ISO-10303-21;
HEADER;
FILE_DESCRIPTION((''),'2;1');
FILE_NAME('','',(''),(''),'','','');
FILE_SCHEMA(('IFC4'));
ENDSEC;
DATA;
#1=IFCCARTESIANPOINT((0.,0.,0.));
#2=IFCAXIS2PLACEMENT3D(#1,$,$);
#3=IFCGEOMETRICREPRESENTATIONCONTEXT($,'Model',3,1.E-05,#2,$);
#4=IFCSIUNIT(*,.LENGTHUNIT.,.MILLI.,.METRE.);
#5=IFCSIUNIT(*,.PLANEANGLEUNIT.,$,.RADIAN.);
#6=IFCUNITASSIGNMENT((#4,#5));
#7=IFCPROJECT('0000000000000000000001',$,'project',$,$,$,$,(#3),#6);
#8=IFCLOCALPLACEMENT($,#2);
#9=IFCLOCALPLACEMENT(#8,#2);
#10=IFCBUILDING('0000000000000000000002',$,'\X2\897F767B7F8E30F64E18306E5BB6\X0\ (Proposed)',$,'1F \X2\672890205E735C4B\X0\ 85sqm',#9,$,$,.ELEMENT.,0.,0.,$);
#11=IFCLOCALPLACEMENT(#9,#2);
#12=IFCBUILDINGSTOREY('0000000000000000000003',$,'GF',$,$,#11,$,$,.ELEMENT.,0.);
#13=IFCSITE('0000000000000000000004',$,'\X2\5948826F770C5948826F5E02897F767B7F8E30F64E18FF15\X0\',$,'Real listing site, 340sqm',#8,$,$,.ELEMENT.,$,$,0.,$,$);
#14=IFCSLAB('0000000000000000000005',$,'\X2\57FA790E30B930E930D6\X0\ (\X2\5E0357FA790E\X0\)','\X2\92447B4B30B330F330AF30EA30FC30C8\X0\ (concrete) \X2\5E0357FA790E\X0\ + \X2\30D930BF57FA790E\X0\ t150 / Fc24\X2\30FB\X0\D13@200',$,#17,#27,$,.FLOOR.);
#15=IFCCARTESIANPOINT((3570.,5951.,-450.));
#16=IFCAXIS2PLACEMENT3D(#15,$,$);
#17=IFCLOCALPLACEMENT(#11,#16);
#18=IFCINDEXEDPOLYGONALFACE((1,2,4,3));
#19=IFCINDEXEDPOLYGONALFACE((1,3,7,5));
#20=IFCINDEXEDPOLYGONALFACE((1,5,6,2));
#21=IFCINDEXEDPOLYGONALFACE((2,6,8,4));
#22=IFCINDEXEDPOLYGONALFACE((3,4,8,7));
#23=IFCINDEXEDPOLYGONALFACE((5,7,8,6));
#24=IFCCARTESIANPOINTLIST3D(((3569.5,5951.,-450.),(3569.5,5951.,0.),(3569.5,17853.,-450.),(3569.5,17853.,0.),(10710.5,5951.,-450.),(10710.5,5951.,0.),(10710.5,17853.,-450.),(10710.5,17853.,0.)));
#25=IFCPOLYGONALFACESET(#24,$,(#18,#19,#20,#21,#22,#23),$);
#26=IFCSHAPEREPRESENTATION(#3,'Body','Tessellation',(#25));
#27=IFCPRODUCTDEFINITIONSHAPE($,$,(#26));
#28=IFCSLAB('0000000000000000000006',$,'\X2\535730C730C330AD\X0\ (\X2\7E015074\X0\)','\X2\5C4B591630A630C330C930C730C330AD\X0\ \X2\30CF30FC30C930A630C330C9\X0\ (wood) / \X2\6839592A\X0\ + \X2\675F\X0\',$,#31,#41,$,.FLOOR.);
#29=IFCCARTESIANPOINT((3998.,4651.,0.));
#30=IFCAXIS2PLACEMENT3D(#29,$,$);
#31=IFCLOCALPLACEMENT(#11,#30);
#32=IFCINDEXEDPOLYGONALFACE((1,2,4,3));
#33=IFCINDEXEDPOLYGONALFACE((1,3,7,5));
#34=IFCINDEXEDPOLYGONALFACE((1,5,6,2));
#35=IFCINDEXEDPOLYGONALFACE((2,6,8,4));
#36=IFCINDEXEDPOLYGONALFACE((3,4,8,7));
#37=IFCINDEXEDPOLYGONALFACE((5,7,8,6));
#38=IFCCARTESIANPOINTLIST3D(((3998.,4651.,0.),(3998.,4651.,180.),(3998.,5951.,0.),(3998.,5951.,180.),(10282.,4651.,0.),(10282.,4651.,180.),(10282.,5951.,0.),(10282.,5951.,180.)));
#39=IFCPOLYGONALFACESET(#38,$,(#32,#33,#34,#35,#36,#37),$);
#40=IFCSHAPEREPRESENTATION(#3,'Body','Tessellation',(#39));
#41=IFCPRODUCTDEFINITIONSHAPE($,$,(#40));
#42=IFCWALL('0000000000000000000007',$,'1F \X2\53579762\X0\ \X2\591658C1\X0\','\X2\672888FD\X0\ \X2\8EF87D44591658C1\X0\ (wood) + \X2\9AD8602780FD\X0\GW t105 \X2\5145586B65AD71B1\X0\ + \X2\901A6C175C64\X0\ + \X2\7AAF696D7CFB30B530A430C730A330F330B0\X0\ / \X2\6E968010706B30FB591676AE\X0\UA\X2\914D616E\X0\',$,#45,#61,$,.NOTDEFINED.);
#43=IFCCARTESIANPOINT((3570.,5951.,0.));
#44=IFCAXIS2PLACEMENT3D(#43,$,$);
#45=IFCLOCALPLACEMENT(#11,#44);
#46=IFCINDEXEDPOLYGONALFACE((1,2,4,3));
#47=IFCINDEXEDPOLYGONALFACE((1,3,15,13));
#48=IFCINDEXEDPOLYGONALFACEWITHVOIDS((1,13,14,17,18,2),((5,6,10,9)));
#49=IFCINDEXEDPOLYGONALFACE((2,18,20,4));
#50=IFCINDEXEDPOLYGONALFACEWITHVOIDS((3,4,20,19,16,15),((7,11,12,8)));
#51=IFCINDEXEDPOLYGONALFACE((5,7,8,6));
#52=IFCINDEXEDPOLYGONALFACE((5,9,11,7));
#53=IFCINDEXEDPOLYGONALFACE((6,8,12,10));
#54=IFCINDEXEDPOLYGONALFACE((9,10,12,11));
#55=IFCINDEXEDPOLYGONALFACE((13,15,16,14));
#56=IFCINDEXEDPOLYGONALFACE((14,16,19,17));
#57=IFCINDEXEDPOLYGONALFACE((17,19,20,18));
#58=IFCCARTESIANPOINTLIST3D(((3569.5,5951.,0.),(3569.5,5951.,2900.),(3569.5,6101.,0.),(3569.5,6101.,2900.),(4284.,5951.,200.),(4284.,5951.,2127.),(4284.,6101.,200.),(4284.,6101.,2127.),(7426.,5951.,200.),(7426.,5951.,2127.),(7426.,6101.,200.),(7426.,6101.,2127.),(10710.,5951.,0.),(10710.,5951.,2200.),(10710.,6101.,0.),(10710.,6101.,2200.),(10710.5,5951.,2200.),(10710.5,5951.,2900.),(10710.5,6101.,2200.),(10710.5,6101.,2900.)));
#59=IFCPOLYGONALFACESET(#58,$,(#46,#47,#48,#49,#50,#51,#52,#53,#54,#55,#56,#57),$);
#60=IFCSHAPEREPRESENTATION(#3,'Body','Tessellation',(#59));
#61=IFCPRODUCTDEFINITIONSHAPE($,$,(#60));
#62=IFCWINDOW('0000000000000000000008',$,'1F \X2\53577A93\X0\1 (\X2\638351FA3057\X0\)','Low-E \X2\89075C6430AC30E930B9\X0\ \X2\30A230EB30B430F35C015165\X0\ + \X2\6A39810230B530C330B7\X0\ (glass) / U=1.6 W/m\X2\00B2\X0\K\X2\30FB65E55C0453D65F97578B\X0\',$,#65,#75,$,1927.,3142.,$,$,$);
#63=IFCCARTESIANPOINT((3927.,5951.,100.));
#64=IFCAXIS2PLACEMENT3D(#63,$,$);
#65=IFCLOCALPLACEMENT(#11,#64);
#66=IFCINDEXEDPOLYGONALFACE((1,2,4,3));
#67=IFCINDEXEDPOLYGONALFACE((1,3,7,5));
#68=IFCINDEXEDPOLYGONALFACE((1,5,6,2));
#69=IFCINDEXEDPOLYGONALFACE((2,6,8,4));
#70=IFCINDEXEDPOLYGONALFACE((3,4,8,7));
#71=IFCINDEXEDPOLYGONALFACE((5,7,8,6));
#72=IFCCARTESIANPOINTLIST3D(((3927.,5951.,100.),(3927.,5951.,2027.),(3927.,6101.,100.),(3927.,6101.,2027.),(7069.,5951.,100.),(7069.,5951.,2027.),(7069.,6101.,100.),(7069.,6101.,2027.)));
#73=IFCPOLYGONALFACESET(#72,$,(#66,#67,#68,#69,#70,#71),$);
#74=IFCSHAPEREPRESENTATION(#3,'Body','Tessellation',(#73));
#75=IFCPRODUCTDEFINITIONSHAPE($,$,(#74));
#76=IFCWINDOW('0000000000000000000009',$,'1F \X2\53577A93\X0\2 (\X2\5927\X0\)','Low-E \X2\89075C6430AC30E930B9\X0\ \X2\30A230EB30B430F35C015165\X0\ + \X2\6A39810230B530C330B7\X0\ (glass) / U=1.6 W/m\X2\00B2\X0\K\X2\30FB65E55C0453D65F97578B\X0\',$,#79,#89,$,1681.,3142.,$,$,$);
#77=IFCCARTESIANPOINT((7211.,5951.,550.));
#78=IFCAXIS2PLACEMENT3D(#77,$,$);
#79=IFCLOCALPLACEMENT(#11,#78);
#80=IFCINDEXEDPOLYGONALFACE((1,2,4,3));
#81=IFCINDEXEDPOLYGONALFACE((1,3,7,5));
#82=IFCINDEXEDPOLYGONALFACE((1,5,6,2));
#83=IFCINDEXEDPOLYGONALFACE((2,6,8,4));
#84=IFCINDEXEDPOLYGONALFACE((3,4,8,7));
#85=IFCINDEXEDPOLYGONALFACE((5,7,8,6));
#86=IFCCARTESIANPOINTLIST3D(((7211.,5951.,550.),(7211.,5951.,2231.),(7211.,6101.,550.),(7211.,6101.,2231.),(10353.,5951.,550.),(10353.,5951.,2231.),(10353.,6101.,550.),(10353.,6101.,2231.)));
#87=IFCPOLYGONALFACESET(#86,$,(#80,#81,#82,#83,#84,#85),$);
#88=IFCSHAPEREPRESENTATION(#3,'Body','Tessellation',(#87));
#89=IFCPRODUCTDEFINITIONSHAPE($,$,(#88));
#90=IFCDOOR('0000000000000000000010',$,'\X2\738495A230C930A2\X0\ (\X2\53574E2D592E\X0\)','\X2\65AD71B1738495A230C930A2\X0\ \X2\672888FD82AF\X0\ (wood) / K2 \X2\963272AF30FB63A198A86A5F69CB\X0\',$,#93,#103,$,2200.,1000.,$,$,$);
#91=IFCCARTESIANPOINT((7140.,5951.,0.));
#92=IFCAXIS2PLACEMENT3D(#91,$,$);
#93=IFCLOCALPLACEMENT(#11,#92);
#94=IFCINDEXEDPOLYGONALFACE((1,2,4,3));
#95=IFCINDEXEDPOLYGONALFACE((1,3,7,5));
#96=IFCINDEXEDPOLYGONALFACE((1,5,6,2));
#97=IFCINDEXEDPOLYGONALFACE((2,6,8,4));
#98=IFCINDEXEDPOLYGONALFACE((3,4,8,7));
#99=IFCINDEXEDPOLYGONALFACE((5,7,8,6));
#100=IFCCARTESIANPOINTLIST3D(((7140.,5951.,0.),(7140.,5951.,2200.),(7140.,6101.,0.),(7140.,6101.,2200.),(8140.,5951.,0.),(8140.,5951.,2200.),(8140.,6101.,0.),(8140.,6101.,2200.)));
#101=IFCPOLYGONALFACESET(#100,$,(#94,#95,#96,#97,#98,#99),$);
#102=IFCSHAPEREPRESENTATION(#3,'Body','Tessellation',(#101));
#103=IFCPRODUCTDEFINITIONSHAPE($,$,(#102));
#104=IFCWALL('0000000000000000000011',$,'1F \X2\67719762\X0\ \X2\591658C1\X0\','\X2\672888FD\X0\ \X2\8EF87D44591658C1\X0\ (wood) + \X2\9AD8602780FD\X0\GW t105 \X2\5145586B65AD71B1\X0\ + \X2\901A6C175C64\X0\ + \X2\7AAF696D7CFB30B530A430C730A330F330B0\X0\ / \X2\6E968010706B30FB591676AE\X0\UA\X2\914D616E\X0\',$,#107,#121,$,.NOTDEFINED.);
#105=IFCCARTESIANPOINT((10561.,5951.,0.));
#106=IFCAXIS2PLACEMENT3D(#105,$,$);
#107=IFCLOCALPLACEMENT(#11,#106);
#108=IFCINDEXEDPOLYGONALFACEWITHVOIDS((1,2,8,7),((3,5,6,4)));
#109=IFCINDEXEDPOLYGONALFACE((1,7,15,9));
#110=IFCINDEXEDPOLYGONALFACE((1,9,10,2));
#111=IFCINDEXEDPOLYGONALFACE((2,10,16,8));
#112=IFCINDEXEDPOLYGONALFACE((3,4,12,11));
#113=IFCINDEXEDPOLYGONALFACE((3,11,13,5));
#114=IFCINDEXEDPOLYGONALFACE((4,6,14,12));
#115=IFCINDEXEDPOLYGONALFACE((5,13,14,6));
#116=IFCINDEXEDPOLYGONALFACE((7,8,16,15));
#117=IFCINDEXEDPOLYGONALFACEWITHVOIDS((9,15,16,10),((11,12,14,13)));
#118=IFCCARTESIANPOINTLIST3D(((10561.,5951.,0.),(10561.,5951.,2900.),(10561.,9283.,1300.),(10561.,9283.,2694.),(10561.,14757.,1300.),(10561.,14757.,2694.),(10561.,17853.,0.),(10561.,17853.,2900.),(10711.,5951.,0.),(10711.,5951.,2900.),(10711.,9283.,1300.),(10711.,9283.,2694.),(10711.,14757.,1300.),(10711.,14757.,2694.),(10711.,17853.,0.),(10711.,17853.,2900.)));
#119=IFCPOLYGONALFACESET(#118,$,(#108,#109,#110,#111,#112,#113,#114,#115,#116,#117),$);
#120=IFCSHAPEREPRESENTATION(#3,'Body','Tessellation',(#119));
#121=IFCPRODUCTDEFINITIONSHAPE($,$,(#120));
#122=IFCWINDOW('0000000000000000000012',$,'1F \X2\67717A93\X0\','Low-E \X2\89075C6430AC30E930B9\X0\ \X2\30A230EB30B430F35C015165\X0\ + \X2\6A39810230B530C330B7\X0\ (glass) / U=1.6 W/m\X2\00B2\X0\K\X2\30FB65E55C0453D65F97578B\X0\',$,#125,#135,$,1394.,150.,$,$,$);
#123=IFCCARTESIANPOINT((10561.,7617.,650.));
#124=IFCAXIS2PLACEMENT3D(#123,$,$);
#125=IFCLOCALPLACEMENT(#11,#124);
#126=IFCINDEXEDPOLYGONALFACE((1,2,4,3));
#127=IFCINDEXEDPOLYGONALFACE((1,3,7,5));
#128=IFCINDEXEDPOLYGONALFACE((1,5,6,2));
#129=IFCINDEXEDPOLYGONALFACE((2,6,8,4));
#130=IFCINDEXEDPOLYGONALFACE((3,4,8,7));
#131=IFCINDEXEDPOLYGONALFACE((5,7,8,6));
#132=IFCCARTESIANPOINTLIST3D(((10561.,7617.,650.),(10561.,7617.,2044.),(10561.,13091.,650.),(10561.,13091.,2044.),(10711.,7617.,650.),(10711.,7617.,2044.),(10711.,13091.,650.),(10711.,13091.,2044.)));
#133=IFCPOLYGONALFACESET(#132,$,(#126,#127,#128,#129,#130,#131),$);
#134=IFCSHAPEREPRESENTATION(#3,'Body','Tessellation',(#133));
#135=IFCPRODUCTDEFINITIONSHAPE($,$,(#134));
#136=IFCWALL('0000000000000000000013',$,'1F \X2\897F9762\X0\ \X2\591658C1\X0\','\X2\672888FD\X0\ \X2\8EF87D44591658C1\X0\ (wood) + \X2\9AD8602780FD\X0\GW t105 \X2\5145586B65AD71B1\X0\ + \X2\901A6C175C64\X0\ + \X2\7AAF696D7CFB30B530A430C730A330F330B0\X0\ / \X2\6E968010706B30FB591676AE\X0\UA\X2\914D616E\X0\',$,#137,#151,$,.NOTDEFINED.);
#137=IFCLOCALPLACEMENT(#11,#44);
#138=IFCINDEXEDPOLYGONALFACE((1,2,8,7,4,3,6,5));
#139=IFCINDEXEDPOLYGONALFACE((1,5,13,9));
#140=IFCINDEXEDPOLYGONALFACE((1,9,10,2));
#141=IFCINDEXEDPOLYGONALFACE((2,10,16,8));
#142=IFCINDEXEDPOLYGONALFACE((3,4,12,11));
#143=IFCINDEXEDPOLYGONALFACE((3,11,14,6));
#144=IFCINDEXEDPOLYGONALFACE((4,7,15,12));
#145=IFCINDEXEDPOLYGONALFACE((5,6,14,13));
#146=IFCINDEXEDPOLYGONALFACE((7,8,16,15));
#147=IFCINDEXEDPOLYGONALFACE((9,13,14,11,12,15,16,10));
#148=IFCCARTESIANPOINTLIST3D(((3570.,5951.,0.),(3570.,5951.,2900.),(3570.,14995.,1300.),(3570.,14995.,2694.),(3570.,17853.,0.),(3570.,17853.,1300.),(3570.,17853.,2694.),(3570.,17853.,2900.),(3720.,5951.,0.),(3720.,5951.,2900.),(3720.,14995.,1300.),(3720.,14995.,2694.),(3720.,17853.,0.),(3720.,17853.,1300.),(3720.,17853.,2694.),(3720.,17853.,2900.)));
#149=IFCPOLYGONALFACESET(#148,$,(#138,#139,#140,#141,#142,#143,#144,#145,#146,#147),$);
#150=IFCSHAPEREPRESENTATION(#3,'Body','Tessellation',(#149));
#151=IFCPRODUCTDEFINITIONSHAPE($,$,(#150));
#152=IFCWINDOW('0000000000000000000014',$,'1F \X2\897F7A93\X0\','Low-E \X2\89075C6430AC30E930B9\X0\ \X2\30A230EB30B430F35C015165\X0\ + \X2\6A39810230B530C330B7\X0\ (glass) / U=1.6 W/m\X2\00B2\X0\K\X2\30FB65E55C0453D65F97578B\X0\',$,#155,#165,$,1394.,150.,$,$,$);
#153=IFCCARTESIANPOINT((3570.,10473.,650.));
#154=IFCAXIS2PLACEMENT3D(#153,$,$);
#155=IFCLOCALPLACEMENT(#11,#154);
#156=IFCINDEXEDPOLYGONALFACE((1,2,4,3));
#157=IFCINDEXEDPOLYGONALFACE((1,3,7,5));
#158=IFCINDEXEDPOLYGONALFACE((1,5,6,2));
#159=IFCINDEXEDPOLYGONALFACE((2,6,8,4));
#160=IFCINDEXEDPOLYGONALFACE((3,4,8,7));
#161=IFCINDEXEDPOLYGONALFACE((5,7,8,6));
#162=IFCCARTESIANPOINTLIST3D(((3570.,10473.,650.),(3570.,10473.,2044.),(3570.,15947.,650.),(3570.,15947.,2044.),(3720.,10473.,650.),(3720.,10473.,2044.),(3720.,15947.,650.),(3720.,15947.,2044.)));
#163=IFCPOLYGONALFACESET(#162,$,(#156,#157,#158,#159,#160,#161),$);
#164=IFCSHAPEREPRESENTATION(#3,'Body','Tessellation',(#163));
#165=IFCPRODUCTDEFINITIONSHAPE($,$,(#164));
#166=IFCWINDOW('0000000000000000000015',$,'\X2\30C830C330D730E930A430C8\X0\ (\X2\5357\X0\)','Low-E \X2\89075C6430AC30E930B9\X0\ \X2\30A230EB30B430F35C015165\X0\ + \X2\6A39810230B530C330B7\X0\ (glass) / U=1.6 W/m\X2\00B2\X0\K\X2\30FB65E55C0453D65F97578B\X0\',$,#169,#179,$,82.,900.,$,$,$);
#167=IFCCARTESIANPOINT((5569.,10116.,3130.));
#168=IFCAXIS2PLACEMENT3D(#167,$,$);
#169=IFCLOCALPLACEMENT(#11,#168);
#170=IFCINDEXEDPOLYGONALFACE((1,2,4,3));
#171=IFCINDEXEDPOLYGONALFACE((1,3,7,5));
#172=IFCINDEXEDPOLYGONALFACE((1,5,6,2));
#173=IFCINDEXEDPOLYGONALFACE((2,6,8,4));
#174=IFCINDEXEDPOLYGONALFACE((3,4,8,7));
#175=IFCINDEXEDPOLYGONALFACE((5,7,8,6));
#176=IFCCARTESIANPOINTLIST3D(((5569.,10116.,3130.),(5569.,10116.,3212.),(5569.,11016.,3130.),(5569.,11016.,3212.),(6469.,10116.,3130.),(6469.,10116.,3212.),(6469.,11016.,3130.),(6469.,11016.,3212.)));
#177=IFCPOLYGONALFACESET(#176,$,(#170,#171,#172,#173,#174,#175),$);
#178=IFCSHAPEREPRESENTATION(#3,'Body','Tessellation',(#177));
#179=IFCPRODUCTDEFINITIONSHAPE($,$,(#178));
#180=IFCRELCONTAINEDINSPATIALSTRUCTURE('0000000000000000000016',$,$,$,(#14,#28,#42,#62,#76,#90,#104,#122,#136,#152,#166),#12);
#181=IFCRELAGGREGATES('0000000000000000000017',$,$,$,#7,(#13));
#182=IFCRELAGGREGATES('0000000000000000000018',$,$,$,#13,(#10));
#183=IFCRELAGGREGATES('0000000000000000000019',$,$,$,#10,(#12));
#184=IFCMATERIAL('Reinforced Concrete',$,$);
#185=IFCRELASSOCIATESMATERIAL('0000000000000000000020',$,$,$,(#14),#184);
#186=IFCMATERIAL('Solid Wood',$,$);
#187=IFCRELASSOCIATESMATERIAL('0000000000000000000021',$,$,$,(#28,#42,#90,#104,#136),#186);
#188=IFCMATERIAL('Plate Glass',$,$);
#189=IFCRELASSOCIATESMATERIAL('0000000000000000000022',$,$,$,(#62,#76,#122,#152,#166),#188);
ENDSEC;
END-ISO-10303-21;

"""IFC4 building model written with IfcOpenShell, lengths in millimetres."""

from ifc_helpers import new_model, si_unit, frame, frame_2d, origin, place, context, project, spatial, rectangle, extrude, material, element, fill, save


model = new_model("IFC4")

# Units and contexts
model_context = context("Model", 3, precision=1e-05, world=origin())
ifc_project = project(units=[si_unit("LENGTHUNIT", "METRE", prefix="MILLI"), si_unit("PLANEANGLEUNIT", "RADIAN")], contexts=[model_context])

# Site, building, storey
site_placement = place(None, origin())
site = spatial("IfcSite", under=ifc_project, at=site_placement, Name="奈良県奈良市西登美ヶ丘５", ObjectType="Real listing site, 340sqm", CompositionType="ELEMENT", RefElevation=0.0)
building_placement = place(site_placement, origin())
building = spatial("IfcBuilding", under=site, at=building_placement, Name="西登美ヶ丘の家 (Proposed)", ObjectType="1F 木造平屋 85sqm", CompositionType="ELEMENT", ElevationOfRefHeight=0.0, ElevationOfTerrain=0.0)
storey_placement = place(building_placement, origin())
storey = spatial("IfcBuildingStorey", under=building, at=storey_placement, Name="GF", CompositionType="ELEMENT", Elevation=0.0)

# Slabs
ifc_material_1 = material(Name="Reinforced Concrete")
slab_1_placement = place(storey_placement, frame((3570.0, 5951.0, -450.0)))
element("IfcSlab", 1, at=slab_1_placement, inside=storey, material=ifc_material_1, Name="基礎スラブ (布基礎)", Description="鉄筋コンクリート (concrete) 布基礎 + ベタ基礎 t150 / Fc24・D13@200", PredefinedType="FLOOR", context=model_context, shape_type="SweptSolid", body=[
    extrude(rectangle(XDim=7141.0, YDim=11902.0, at=frame_2d((3570.0, 5951.0))), frame((3570.0, 5951.0, -450.0)), (0.0, 0.0, 1.0), 450.0),
])
ifc_material_2 = material(Name="Solid Wood")
slab_2_placement = place(storey_placement, frame((3998.0, 4651.0, 0.0)))
element("IfcSlab", 2, at=slab_2_placement, inside=storey, material=ifc_material_2, Name="南デッキ (縁側)", Description="屋外ウッドデッキ ハードウッド (wood) / 根太 + 束", PredefinedType="FLOOR", context=model_context, shape_type="SweptSolid", body=[
    extrude(rectangle(XDim=6284.0, YDim=1300.0, at=frame_2d((3142.0, 650.0))), frame((3998.0, 4651.0, 0.0)), (0.0, 0.0, 1.0), 180.0),
])

# Wall, openings, windows, door
wall_1_placement = place(storey_placement, frame((3570.0, 5951.0, 0.0)))
wall_1 = element("IfcWall", 3, at=wall_1_placement, inside=storey, material=ifc_material_2, Name="1F 南面 外壁", Description="木製 軸組外壁 (wood) + 高性能GW t105 充填断熱 + 通気層 + 窯業系サイディング / 準耐火・外皮UA配慮", PredefinedType="NOTDEFINED", context=model_context, shape_type="SweptSolid", body=[
    extrude(rectangle(XDim=7141.0, YDim=150.0, at=frame_2d((3570.0, 75.0))), frame((3570.0, 5951.0, 0.0)), (0.0, 0.0, 1.0), 2900.0),
])
opening_1_placement = place(storey_placement, frame((3927.0, 5951.0, 100.0)))
opening_1 = element("IfcOpeningElement", 4, at=opening_1_placement, cuts=wall_1, PredefinedType="NOTDEFINED", context=model_context, shape_type="SweptSolid", body=[
    extrude(rectangle(XDim=3142.0, YDim=150.0, at=frame_2d((1571.0, 75.0))), frame((3927.0, 5951.0, 100.0)), (0.0, 0.0, 1.0), 1927.0),
])
opening_2_placement = place(storey_placement, frame((7211.0, 5951.0, 550.0)))
opening_2 = element("IfcOpeningElement", 5, at=opening_2_placement, cuts=wall_1, PredefinedType="NOTDEFINED", context=model_context, shape_type="SweptSolid", body=[
    extrude(rectangle(XDim=3142.0, YDim=150.0, at=frame_2d((1571.0, 75.0))), frame((7211.0, 5951.0, 550.0)), (0.0, 0.0, 1.0), 1681.0),
])
opening_3_placement = place(storey_placement, frame((7140.0, 5951.0, 0.0)))
opening_3 = element("IfcOpeningElement", 6, at=opening_3_placement, cuts=wall_1, PredefinedType="NOTDEFINED", context=model_context, shape_type="SweptSolid", body=[
    extrude(rectangle(XDim=1000.0, YDim=150.0, at=frame_2d((500.0, 75.0))), frame((7140.0, 5951.0, 0.0)), (0.0, 0.0, 1.0), 2200.0),
])
ifc_material_3 = material(Name="Plate Glass")
window_1_placement = place(storey_placement, frame((3927.0, 5951.0, 100.0)))
window_1 = element("IfcWindow", 7, at=window_1_placement, inside=storey, material=ifc_material_3, Name="1F 南窓1 (掃出し)", Description="Low-E 複層ガラス アルゴン封入 + 樹脂サッシ (glass) / U=1.6 W/m²K・日射取得型", OverallHeight=1927.0, OverallWidth=3142.0, context=model_context, shape_type="SweptSolid", body=[
    extrude(rectangle(XDim=3142.0, YDim=150.0, at=frame_2d((1571.0, 75.0))), frame((3927.0, 5951.0, 100.0)), (0.0, 0.0, 1.0), 1927.0),
])
fill(opening_1, window_1)
window_2_placement = place(storey_placement, frame((7211.0, 5951.0, 550.0)))
window_2 = element("IfcWindow", 8, at=window_2_placement, inside=storey, material=ifc_material_3, Name="1F 南窓2 (大)", Description="Low-E 複層ガラス アルゴン封入 + 樹脂サッシ (glass) / U=1.6 W/m²K・日射取得型", OverallHeight=1681.0, OverallWidth=3142.0, context=model_context, shape_type="SweptSolid", body=[
    extrude(rectangle(XDim=3142.0, YDim=150.0, at=frame_2d((1571.0, 75.0))), frame((7211.0, 5951.0, 550.0)), (0.0, 0.0, 1.0), 1681.0),
])
fill(opening_2, window_2)
door_placement = place(storey_placement, frame((7140.0, 5951.0, 0.0)))
door = element("IfcDoor", 9, at=door_placement, inside=storey, material=ifc_material_2, Name="玄関ドア (南中央)", Description="断熱玄関ドア 木製芯 (wood) / K2 防犯・採風機構", OverallHeight=2200.0, OverallWidth=1000.0, context=model_context, shape_type="SweptSolid", body=[
    extrude(rectangle(XDim=1000.0, YDim=150.0, at=frame_2d((500.0, 75.0))), frame((7140.0, 5951.0, 0.0)), (0.0, 0.0, 1.0), 2200.0),
])
fill(opening_3, door)

# Walls, openings, windows
wall_2_placement = place(storey_placement, frame((10561.0, 5951.0, 0.0)))
wall_2 = element("IfcWall", 10, at=wall_2_placement, inside=storey, material=ifc_material_2, Name="1F 東面 外壁", Description="木製 軸組外壁 (wood) + 高性能GW t105 充填断熱 + 通気層 + 窯業系サイディング / 準耐火・外皮UA配慮", PredefinedType="NOTDEFINED", context=model_context, shape_type="SweptSolid", body=[
    extrude(rectangle(XDim=150.0, YDim=11902.0, at=frame_2d((75.0, 5951.0))), frame((10561.0, 5951.0, 0.0)), (0.0, 0.0, 1.0), 2900.0),
])
opening_4_placement = place(storey_placement, frame((10561.0, 7617.0, 650.0)))
opening_4 = element("IfcOpeningElement", 11, at=opening_4_placement, cuts=wall_2, PredefinedType="NOTDEFINED", context=model_context, shape_type="SweptSolid", body=[
    extrude(rectangle(XDim=150.0, YDim=5474.0, at=frame_2d((75.0, 2737.0))), frame((10561.0, 7617.0, 650.0)), (0.0, 0.0, 1.0), 1394.0),
])
window_3_placement = place(storey_placement, frame((10561.0, 7617.0, 650.0)))
window_3 = element("IfcWindow", 12, at=window_3_placement, inside=storey, material=ifc_material_3, Name="1F 東窓", Description="Low-E 複層ガラス アルゴン封入 + 樹脂サッシ (glass) / U=1.6 W/m²K・日射取得型", OverallHeight=1394.0, OverallWidth=150.0, context=model_context, shape_type="SweptSolid", body=[
    extrude(rectangle(XDim=150.0, YDim=5474.0, at=frame_2d((75.0, 2737.0))), frame((10561.0, 7617.0, 650.0)), (0.0, 0.0, 1.0), 1394.0),
])
fill(opening_4, window_3)
wall_3_placement = place(storey_placement, frame((3570.0, 5951.0, 0.0)))
wall_3 = element("IfcWall", 13, at=wall_3_placement, inside=storey, material=ifc_material_2, Name="1F 西面 外壁", Description="木製 軸組外壁 (wood) + 高性能GW t105 充填断熱 + 通気層 + 窯業系サイディング / 準耐火・外皮UA配慮", PredefinedType="NOTDEFINED", context=model_context, shape_type="SweptSolid", body=[
    extrude(rectangle(XDim=150.0, YDim=11902.0, at=frame_2d((75.0, 5951.0))), frame((3570.0, 5951.0, 0.0)), (0.0, 0.0, 1.0), 2900.0),
])
opening_5_placement = place(storey_placement, frame((3570.0, 10473.0, 650.0)))
opening_5 = element("IfcOpeningElement", 14, at=opening_5_placement, cuts=wall_3, PredefinedType="NOTDEFINED", context=model_context, shape_type="SweptSolid", body=[
    extrude(rectangle(XDim=150.0, YDim=5474.0, at=frame_2d((75.0, 2737.0))), frame((3570.0, 10473.0, 650.0)), (0.0, 0.0, 1.0), 1394.0),
])
window_4_placement = place(storey_placement, frame((3570.0, 10473.0, 650.0)))
window_4 = element("IfcWindow", 15, at=window_4_placement, inside=storey, material=ifc_material_3, Name="1F 西窓", Description="Low-E 複層ガラス アルゴン封入 + 樹脂サッシ (glass) / U=1.6 W/m²K・日射取得型", OverallHeight=1394.0, OverallWidth=150.0, context=model_context, shape_type="SweptSolid", body=[
    extrude(rectangle(XDim=150.0, YDim=5474.0, at=frame_2d((75.0, 2737.0))), frame((3570.0, 10473.0, 650.0)), (0.0, 0.0, 1.0), 1394.0),
])
fill(opening_5, window_4)

# Window
window_5_placement = place(storey_placement, frame((5569.0, 10116.0, 3130.0)))
element("IfcWindow", 16, at=window_5_placement, inside=storey, material=ifc_material_3, Name="トップライト (南)", Description="Low-E 複層ガラス アルゴン封入 + 樹脂サッシ (glass) / U=1.6 W/m²K・日射取得型", OverallHeight=82.0, OverallWidth=900.0, context=model_context, shape_type="SweptSolid", body=[
    extrude(rectangle(XDim=900.0, YDim=900.0, at=frame_2d((450.0, 450.0))), frame((5569.0, 10116.0, 3130.0)), (0.0, 0.0, 1.0), 82.0),
])

save(model, "model.ifc")
